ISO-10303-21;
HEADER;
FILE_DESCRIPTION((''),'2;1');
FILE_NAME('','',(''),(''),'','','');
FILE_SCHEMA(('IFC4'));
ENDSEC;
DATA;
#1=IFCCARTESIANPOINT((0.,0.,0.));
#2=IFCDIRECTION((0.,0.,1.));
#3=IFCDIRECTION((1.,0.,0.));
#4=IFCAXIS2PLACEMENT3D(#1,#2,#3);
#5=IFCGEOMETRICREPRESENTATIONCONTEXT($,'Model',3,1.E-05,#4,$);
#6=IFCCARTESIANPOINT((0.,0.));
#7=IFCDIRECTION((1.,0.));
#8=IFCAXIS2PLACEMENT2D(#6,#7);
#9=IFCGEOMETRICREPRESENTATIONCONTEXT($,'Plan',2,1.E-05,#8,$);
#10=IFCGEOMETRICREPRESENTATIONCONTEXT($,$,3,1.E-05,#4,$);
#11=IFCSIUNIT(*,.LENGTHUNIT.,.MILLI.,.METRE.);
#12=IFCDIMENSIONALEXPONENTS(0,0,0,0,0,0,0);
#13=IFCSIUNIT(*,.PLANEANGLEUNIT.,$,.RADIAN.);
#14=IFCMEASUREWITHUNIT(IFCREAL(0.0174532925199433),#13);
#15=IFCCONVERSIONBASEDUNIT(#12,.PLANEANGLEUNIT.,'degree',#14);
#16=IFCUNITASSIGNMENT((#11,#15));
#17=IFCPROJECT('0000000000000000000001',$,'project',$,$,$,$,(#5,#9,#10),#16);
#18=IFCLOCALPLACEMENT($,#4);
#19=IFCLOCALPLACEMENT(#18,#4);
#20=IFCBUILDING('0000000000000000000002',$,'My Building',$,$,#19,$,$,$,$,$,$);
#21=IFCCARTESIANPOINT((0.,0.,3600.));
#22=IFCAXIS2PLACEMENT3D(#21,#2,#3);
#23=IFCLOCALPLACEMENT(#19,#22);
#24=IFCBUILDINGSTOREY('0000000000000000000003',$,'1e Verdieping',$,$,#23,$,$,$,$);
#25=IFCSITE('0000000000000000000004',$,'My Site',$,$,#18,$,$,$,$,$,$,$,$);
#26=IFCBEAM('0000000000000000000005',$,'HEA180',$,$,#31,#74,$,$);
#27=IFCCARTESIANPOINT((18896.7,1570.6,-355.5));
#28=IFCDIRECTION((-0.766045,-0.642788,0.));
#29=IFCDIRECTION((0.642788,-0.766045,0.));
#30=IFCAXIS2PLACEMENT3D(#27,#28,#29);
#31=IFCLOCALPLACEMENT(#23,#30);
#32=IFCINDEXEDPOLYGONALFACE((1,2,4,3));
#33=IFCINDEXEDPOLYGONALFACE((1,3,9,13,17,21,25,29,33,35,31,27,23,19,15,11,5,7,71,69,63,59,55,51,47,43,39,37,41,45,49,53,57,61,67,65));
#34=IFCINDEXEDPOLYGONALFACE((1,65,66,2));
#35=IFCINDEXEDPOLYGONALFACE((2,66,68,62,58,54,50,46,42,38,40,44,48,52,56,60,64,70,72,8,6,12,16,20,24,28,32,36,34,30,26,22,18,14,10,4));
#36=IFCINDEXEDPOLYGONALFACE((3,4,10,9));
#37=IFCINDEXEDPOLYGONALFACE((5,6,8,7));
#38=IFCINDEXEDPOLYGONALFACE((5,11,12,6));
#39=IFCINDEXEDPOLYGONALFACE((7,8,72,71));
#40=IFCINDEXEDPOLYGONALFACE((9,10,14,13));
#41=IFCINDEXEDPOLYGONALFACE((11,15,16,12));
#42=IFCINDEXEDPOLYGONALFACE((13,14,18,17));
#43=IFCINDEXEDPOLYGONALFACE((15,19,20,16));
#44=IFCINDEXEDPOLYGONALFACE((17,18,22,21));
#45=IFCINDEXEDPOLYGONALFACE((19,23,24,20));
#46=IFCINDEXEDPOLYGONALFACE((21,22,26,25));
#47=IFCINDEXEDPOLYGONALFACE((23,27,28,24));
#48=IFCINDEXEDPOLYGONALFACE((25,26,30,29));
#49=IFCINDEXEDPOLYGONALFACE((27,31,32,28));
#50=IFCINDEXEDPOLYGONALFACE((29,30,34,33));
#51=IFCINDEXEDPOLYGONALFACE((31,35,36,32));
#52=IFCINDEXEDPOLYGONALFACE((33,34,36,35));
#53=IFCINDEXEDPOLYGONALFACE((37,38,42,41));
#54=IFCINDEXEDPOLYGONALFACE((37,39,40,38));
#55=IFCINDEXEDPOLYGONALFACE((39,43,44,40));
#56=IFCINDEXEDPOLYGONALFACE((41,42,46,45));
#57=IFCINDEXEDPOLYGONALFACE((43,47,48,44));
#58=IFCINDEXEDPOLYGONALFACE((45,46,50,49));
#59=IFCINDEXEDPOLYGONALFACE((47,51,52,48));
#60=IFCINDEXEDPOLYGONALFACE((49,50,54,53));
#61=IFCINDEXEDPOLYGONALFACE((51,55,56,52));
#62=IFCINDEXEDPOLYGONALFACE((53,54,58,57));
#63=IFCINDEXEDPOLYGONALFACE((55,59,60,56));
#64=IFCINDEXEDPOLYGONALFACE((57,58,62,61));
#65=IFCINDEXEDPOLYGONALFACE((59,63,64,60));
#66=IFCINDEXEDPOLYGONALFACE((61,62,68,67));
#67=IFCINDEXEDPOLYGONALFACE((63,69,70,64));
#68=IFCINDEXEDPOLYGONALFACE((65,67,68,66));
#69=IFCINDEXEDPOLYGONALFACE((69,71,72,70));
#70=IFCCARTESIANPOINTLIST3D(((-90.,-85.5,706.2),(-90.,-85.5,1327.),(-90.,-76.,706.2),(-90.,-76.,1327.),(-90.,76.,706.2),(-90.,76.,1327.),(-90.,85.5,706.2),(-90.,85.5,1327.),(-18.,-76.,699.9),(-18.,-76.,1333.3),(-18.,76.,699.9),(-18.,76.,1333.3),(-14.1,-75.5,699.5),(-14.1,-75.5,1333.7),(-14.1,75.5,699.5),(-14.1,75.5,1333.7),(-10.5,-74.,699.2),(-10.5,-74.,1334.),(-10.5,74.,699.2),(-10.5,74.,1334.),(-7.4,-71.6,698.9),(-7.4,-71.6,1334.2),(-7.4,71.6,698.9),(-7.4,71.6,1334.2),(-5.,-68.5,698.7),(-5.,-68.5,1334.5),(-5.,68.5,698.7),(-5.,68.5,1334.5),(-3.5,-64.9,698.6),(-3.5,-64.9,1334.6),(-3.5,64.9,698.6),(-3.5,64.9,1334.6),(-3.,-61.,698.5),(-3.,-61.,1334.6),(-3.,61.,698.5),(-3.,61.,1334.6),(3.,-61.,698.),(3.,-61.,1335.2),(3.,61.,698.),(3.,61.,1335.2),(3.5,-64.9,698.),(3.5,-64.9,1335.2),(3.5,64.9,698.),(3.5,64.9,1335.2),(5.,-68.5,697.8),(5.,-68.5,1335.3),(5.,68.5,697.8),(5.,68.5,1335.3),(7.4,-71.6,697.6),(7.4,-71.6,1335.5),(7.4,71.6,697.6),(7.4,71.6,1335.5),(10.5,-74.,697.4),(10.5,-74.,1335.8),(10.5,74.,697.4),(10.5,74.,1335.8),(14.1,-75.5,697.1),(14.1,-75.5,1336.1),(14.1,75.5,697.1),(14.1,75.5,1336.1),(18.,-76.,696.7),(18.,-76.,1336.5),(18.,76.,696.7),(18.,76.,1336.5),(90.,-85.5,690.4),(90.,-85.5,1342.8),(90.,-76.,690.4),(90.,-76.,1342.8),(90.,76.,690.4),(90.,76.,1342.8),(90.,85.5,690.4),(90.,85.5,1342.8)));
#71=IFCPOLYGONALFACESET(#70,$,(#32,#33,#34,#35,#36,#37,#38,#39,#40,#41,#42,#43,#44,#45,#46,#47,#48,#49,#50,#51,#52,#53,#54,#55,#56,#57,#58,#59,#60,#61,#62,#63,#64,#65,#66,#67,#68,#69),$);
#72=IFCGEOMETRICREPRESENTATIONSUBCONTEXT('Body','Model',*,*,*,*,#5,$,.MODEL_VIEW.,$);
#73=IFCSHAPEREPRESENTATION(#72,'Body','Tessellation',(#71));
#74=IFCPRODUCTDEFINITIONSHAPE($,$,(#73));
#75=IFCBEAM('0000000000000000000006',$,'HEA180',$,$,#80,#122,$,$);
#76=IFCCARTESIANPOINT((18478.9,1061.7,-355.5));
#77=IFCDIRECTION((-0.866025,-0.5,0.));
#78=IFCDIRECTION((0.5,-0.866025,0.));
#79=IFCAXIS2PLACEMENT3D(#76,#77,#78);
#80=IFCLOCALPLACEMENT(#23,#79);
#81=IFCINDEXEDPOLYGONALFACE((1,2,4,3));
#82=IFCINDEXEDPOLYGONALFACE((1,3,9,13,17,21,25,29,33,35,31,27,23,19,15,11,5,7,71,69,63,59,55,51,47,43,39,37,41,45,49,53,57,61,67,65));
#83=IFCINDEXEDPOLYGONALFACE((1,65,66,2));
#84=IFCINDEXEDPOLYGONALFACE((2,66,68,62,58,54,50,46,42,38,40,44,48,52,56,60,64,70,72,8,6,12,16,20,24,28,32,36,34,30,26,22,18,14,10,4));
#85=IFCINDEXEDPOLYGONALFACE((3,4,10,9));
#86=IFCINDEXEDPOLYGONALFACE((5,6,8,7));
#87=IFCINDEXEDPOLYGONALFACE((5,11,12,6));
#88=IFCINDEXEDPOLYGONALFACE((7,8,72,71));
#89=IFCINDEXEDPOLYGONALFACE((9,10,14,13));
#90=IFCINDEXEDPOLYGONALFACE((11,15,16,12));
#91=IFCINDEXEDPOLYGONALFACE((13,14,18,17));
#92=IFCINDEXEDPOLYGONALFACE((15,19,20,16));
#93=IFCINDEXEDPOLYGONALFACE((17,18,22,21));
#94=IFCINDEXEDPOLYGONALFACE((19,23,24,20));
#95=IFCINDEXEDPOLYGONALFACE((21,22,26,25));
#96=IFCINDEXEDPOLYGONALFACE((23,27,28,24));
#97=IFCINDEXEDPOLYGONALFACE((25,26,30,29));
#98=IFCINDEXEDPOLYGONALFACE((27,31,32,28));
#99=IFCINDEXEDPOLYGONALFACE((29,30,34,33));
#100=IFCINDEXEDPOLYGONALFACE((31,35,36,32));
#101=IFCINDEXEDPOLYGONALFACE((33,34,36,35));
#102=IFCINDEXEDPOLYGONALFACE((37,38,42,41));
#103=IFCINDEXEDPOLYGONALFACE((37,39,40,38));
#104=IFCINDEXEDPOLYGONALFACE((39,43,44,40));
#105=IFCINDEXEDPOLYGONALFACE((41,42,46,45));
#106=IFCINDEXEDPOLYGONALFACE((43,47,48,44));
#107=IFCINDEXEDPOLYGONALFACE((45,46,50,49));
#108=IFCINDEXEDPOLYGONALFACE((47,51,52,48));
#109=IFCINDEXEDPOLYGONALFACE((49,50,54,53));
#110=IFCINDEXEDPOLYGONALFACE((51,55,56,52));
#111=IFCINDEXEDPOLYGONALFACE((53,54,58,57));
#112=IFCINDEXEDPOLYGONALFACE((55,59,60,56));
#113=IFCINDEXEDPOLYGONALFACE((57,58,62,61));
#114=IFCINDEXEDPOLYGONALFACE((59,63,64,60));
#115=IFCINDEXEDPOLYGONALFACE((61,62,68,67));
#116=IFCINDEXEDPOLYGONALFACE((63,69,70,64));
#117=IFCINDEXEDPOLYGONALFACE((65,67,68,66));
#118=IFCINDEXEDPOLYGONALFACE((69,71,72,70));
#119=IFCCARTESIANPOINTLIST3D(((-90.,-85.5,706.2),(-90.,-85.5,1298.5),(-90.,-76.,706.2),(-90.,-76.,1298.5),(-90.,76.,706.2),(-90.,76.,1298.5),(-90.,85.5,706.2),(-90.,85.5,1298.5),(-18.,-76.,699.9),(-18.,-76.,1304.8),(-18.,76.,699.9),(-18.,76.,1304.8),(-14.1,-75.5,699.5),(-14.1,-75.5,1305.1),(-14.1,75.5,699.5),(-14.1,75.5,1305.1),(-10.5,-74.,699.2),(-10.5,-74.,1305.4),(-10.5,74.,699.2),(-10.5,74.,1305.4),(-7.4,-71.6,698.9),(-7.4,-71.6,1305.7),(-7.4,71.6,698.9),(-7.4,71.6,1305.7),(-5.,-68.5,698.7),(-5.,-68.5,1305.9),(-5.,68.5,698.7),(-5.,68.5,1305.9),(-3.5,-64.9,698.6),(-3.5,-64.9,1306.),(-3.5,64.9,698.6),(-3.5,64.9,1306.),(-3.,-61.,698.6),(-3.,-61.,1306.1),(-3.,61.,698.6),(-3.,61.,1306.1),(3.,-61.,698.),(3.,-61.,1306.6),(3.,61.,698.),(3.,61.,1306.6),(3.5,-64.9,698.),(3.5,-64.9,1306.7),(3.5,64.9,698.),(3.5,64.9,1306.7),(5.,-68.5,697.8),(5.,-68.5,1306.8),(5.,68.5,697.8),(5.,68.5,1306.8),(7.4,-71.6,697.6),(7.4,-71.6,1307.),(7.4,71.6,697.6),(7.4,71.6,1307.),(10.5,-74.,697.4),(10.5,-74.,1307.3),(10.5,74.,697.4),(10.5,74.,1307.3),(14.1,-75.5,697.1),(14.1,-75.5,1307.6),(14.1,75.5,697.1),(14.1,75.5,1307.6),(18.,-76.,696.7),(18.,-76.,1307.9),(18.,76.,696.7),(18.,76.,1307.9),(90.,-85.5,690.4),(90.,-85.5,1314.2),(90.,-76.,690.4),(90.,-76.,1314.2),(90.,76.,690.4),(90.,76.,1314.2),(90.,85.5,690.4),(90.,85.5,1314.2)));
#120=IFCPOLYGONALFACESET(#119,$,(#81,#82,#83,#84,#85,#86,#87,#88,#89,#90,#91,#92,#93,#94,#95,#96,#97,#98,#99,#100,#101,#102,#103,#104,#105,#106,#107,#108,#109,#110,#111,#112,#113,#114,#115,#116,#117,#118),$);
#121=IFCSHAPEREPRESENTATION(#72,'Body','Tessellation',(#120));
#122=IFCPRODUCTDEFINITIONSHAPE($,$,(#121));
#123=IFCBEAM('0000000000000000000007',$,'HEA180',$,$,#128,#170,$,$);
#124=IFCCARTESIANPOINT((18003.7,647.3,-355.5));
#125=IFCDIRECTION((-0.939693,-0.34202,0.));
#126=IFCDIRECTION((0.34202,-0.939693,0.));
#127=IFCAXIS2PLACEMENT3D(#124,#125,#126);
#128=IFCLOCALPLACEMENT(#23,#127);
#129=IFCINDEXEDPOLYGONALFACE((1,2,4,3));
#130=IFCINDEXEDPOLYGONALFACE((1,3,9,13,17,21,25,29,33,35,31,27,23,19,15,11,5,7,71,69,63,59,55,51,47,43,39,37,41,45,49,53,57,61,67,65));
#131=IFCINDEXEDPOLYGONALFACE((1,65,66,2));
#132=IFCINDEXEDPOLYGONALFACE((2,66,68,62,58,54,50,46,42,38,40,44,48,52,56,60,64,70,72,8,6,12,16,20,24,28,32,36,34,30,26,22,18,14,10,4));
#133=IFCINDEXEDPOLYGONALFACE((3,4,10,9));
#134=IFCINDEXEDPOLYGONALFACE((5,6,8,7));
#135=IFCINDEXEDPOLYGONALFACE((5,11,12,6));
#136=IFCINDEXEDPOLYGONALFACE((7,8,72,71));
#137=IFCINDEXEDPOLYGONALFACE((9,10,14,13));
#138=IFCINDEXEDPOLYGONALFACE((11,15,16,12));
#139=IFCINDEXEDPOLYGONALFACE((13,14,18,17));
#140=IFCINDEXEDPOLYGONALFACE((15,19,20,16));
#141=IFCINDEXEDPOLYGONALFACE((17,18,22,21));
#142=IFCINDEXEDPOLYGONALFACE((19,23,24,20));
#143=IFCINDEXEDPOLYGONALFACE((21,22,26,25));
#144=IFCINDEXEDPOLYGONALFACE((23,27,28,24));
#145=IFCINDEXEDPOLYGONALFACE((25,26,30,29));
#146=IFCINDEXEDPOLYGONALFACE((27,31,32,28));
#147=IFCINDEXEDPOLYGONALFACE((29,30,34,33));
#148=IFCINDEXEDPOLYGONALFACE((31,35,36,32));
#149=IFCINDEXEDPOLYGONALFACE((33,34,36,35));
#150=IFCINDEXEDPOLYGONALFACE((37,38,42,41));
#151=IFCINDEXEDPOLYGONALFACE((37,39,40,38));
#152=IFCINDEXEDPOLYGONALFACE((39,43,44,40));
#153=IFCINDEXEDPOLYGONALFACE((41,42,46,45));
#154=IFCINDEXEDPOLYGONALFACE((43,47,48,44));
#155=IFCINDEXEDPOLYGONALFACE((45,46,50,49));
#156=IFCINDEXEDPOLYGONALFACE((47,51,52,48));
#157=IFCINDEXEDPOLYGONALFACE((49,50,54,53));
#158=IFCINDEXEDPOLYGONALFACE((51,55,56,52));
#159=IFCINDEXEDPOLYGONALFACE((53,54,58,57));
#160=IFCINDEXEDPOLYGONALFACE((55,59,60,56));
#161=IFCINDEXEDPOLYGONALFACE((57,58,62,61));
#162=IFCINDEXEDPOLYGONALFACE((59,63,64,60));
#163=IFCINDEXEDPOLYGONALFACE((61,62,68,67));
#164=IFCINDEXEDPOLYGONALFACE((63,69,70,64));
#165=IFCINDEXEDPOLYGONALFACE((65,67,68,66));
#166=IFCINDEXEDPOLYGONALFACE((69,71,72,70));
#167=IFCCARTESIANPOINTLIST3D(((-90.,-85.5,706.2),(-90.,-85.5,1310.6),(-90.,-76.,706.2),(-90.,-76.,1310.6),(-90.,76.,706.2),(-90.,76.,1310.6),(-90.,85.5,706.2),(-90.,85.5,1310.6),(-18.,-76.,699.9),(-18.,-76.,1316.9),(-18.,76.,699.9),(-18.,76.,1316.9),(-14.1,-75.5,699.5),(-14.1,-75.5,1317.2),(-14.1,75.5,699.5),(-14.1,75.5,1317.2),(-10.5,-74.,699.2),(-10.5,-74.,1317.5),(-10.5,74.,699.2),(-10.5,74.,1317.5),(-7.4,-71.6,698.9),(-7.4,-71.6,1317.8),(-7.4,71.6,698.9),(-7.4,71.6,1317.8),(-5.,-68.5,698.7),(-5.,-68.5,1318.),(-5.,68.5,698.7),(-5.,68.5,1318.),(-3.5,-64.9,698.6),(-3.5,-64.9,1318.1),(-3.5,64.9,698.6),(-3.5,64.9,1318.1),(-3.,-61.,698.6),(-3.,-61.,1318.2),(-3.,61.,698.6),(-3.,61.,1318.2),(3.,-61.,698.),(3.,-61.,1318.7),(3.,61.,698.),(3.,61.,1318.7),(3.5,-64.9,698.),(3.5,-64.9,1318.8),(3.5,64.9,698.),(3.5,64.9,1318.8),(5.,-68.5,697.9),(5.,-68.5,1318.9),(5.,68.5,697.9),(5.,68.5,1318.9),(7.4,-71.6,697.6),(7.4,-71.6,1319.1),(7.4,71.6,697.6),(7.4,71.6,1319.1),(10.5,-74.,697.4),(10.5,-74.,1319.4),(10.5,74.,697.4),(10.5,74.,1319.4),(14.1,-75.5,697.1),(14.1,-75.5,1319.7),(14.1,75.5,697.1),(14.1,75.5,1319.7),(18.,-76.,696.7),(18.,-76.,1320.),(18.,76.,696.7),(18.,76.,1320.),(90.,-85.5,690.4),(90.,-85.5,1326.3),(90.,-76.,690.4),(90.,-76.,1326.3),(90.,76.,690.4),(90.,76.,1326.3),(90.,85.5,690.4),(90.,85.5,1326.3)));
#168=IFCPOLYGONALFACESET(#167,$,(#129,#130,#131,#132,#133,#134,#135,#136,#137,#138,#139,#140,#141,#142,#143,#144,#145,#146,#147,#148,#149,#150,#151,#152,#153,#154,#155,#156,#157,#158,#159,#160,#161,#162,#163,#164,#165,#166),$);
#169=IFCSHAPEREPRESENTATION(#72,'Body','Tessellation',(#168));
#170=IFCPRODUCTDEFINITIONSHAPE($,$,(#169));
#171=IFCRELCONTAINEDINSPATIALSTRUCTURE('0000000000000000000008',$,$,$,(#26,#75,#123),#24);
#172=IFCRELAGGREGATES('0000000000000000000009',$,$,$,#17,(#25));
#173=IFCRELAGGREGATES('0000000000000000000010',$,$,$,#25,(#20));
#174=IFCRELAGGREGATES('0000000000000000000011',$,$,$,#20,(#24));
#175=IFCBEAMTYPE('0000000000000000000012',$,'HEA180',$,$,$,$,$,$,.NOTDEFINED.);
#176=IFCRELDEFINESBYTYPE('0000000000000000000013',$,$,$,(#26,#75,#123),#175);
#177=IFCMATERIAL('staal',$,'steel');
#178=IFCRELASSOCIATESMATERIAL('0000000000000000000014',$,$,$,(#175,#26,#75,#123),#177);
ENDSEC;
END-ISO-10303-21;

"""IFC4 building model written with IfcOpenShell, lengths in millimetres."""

from ifc_helpers import new_model, entity, si_unit, converted_unit, frame, origin_with_axes, origin_2d_with_axis, place, context, subcontext, project, spatial, i_section, extrude, clip, halfspace, material, material_profile, profile_set, profile_usage, type_object, element, save


model = new_model("IFC4")

# Units and contexts
model_context = context("Model", 3, precision=1e-05, world=origin_with_axes())
plan_context = context("Plan", 2, precision=1e-05, world=origin_2d_with_axis())
context_of_model = context(None, 3, precision=1e-05, world=origin_with_axes())
body_context = subcontext(model_context, "Body", "Model", "MODEL_VIEW")
ifc_project = project(units=[si_unit("LENGTHUNIT", "METRE", prefix="MILLI"), converted_unit("PLANEANGLEUNIT", "degree", entity("IfcReal", 0.0174532925199433), si_unit("PLANEANGLEUNIT", "RADIAN"), dimensions=[0, 0, 0, 0, 0, 0, 0])], contexts=[model_context, plan_context, context_of_model])

# Site, building, storey
site_placement = place(None, origin_with_axes())
site = spatial("IfcSite", under=ifc_project, at=site_placement, Name="My Site")
building_placement = place(site_placement, origin_with_axes())
building = spatial("IfcBuilding", under=site, at=building_placement, Name="My Building")
storey_placement = place(building_placement, frame((0.0, 0.0, 3600.0), z_axis=(0.0, 0.0, 1.0), x_axis=(1.0, 0.0, 0.0)))
storey = spatial("IfcBuildingStorey", under=building, at=storey_placement, Name="1e Verdieping")

# Shared definitions
ifc_material = material(Name="staal", Category="steel")

# Beams
ifc_material_profile_1 = material_profile(ifc_material, i_section(OverallWidth=180.0, OverallDepth=171.0, WebThickness=6.0, FlangeThickness=9.5, FilletRadius=15.0))
ifc_profile_set_1 = profile_set([ifc_material_profile_1], Name="HEA180")
beam_type_1 = type_object("IfcBeamType", Name="HEA180", PredefinedType="NOTDEFINED", material=ifc_profile_set_1)
ifc_profile_usage_1 = profile_usage(ifc_profile_set_1)
beam_1_placement = place(storey_placement, frame((18896.7, 1570.6, -355.5), z_axis=(-0.766045, -0.642788, 0.0), x_axis=(0.642788, -0.766045, 0.0)))
element("IfcBeam", 1, at=beam_1_placement, inside=storey, type_object=beam_type_1, material=ifc_profile_usage_1, Name="HEA180", context=body_context, shape_type="Clipping", body=[
    clip(clip(extrude(i_section(OverallWidth=180.0, OverallDepth=171.0, WebThickness=6.0, FlangeThickness=9.5, FilletRadius=15.0), origin_with_axes(), (0.0, 0.0, 1.0), 2033.2), halfspace(frame((90.0, -3254.0, 690.4), z_axis=(-0.087118, 0.0, -0.996198), x_axis=(0.000001, 1.0, 0.0)), False)), halfspace(frame((90.0, -3254.0, 1342.8), z_axis=(-0.087142, 0.0, 0.996196), x_axis=(0.000003, 1.0, 0.0)), False)),
])
ifc_profile_usage_2 = profile_usage(ifc_profile_set_1)
beam_2_placement = place(storey_placement, frame((18478.9, 1061.7, -355.5), z_axis=(-0.866025, -0.5, 0.0), x_axis=(0.5, -0.866025, 0.0)))
element("IfcBeam", 2, at=beam_2_placement, inside=storey, type_object=beam_type_1, material=ifc_profile_usage_2, Name="HEA180", context=body_context, shape_type="Clipping", body=[
    clip(clip(extrude(i_section(OverallWidth=180.0, OverallDepth=171.0, WebThickness=6.0, FlangeThickness=9.5, FilletRadius=15.0), origin_with_axes(), (0.0, 0.0, 1.0), 2004.6), halfspace(frame((90.0, -3235.0, 690.4), z_axis=(-0.087185, 0.0, -0.996192), x_axis=(-0.000003, 1.0, 0.0)), False)), halfspace(frame((90.0, -3235.0, 1314.2), z_axis=(-0.087181, -0.000001, 0.996192), x_axis=(-0.000007, 1.0, 0.0)), False)),
])
ifc_profile_usage_3 = profile_usage(ifc_profile_set_1)
beam_3_placement = place(storey_placement, frame((18003.7, 647.3, -355.5), z_axis=(-0.939693, -0.34202, 0.0), x_axis=(0.34202, -0.939693, 0.0)))
element("IfcBeam", 3, at=beam_3_placement, inside=storey, type_object=beam_type_1, material=ifc_profile_usage_3, Name="HEA180", context=body_context, shape_type="Clipping", body=[
    clip(clip(extrude(i_section(OverallWidth=180.0, OverallDepth=171.0, WebThickness=6.0, FlangeThickness=9.5, FilletRadius=15.0), origin_with_axes(), (0.0, 0.0, 1.0), 2016.7), halfspace(frame((90.0, -3244.5, 1326.3), z_axis=(-0.087151, 0.0, 0.996195), x_axis=(-0.000001, 1.0, 0.0)), False)), halfspace(frame((90.0, -3244.5, 690.4), z_axis=(-0.08716, 0.0, -0.996194), x_axis=(0.000005, 1.0, 0.0)), False)),
])

save(model, "model.ifc")
